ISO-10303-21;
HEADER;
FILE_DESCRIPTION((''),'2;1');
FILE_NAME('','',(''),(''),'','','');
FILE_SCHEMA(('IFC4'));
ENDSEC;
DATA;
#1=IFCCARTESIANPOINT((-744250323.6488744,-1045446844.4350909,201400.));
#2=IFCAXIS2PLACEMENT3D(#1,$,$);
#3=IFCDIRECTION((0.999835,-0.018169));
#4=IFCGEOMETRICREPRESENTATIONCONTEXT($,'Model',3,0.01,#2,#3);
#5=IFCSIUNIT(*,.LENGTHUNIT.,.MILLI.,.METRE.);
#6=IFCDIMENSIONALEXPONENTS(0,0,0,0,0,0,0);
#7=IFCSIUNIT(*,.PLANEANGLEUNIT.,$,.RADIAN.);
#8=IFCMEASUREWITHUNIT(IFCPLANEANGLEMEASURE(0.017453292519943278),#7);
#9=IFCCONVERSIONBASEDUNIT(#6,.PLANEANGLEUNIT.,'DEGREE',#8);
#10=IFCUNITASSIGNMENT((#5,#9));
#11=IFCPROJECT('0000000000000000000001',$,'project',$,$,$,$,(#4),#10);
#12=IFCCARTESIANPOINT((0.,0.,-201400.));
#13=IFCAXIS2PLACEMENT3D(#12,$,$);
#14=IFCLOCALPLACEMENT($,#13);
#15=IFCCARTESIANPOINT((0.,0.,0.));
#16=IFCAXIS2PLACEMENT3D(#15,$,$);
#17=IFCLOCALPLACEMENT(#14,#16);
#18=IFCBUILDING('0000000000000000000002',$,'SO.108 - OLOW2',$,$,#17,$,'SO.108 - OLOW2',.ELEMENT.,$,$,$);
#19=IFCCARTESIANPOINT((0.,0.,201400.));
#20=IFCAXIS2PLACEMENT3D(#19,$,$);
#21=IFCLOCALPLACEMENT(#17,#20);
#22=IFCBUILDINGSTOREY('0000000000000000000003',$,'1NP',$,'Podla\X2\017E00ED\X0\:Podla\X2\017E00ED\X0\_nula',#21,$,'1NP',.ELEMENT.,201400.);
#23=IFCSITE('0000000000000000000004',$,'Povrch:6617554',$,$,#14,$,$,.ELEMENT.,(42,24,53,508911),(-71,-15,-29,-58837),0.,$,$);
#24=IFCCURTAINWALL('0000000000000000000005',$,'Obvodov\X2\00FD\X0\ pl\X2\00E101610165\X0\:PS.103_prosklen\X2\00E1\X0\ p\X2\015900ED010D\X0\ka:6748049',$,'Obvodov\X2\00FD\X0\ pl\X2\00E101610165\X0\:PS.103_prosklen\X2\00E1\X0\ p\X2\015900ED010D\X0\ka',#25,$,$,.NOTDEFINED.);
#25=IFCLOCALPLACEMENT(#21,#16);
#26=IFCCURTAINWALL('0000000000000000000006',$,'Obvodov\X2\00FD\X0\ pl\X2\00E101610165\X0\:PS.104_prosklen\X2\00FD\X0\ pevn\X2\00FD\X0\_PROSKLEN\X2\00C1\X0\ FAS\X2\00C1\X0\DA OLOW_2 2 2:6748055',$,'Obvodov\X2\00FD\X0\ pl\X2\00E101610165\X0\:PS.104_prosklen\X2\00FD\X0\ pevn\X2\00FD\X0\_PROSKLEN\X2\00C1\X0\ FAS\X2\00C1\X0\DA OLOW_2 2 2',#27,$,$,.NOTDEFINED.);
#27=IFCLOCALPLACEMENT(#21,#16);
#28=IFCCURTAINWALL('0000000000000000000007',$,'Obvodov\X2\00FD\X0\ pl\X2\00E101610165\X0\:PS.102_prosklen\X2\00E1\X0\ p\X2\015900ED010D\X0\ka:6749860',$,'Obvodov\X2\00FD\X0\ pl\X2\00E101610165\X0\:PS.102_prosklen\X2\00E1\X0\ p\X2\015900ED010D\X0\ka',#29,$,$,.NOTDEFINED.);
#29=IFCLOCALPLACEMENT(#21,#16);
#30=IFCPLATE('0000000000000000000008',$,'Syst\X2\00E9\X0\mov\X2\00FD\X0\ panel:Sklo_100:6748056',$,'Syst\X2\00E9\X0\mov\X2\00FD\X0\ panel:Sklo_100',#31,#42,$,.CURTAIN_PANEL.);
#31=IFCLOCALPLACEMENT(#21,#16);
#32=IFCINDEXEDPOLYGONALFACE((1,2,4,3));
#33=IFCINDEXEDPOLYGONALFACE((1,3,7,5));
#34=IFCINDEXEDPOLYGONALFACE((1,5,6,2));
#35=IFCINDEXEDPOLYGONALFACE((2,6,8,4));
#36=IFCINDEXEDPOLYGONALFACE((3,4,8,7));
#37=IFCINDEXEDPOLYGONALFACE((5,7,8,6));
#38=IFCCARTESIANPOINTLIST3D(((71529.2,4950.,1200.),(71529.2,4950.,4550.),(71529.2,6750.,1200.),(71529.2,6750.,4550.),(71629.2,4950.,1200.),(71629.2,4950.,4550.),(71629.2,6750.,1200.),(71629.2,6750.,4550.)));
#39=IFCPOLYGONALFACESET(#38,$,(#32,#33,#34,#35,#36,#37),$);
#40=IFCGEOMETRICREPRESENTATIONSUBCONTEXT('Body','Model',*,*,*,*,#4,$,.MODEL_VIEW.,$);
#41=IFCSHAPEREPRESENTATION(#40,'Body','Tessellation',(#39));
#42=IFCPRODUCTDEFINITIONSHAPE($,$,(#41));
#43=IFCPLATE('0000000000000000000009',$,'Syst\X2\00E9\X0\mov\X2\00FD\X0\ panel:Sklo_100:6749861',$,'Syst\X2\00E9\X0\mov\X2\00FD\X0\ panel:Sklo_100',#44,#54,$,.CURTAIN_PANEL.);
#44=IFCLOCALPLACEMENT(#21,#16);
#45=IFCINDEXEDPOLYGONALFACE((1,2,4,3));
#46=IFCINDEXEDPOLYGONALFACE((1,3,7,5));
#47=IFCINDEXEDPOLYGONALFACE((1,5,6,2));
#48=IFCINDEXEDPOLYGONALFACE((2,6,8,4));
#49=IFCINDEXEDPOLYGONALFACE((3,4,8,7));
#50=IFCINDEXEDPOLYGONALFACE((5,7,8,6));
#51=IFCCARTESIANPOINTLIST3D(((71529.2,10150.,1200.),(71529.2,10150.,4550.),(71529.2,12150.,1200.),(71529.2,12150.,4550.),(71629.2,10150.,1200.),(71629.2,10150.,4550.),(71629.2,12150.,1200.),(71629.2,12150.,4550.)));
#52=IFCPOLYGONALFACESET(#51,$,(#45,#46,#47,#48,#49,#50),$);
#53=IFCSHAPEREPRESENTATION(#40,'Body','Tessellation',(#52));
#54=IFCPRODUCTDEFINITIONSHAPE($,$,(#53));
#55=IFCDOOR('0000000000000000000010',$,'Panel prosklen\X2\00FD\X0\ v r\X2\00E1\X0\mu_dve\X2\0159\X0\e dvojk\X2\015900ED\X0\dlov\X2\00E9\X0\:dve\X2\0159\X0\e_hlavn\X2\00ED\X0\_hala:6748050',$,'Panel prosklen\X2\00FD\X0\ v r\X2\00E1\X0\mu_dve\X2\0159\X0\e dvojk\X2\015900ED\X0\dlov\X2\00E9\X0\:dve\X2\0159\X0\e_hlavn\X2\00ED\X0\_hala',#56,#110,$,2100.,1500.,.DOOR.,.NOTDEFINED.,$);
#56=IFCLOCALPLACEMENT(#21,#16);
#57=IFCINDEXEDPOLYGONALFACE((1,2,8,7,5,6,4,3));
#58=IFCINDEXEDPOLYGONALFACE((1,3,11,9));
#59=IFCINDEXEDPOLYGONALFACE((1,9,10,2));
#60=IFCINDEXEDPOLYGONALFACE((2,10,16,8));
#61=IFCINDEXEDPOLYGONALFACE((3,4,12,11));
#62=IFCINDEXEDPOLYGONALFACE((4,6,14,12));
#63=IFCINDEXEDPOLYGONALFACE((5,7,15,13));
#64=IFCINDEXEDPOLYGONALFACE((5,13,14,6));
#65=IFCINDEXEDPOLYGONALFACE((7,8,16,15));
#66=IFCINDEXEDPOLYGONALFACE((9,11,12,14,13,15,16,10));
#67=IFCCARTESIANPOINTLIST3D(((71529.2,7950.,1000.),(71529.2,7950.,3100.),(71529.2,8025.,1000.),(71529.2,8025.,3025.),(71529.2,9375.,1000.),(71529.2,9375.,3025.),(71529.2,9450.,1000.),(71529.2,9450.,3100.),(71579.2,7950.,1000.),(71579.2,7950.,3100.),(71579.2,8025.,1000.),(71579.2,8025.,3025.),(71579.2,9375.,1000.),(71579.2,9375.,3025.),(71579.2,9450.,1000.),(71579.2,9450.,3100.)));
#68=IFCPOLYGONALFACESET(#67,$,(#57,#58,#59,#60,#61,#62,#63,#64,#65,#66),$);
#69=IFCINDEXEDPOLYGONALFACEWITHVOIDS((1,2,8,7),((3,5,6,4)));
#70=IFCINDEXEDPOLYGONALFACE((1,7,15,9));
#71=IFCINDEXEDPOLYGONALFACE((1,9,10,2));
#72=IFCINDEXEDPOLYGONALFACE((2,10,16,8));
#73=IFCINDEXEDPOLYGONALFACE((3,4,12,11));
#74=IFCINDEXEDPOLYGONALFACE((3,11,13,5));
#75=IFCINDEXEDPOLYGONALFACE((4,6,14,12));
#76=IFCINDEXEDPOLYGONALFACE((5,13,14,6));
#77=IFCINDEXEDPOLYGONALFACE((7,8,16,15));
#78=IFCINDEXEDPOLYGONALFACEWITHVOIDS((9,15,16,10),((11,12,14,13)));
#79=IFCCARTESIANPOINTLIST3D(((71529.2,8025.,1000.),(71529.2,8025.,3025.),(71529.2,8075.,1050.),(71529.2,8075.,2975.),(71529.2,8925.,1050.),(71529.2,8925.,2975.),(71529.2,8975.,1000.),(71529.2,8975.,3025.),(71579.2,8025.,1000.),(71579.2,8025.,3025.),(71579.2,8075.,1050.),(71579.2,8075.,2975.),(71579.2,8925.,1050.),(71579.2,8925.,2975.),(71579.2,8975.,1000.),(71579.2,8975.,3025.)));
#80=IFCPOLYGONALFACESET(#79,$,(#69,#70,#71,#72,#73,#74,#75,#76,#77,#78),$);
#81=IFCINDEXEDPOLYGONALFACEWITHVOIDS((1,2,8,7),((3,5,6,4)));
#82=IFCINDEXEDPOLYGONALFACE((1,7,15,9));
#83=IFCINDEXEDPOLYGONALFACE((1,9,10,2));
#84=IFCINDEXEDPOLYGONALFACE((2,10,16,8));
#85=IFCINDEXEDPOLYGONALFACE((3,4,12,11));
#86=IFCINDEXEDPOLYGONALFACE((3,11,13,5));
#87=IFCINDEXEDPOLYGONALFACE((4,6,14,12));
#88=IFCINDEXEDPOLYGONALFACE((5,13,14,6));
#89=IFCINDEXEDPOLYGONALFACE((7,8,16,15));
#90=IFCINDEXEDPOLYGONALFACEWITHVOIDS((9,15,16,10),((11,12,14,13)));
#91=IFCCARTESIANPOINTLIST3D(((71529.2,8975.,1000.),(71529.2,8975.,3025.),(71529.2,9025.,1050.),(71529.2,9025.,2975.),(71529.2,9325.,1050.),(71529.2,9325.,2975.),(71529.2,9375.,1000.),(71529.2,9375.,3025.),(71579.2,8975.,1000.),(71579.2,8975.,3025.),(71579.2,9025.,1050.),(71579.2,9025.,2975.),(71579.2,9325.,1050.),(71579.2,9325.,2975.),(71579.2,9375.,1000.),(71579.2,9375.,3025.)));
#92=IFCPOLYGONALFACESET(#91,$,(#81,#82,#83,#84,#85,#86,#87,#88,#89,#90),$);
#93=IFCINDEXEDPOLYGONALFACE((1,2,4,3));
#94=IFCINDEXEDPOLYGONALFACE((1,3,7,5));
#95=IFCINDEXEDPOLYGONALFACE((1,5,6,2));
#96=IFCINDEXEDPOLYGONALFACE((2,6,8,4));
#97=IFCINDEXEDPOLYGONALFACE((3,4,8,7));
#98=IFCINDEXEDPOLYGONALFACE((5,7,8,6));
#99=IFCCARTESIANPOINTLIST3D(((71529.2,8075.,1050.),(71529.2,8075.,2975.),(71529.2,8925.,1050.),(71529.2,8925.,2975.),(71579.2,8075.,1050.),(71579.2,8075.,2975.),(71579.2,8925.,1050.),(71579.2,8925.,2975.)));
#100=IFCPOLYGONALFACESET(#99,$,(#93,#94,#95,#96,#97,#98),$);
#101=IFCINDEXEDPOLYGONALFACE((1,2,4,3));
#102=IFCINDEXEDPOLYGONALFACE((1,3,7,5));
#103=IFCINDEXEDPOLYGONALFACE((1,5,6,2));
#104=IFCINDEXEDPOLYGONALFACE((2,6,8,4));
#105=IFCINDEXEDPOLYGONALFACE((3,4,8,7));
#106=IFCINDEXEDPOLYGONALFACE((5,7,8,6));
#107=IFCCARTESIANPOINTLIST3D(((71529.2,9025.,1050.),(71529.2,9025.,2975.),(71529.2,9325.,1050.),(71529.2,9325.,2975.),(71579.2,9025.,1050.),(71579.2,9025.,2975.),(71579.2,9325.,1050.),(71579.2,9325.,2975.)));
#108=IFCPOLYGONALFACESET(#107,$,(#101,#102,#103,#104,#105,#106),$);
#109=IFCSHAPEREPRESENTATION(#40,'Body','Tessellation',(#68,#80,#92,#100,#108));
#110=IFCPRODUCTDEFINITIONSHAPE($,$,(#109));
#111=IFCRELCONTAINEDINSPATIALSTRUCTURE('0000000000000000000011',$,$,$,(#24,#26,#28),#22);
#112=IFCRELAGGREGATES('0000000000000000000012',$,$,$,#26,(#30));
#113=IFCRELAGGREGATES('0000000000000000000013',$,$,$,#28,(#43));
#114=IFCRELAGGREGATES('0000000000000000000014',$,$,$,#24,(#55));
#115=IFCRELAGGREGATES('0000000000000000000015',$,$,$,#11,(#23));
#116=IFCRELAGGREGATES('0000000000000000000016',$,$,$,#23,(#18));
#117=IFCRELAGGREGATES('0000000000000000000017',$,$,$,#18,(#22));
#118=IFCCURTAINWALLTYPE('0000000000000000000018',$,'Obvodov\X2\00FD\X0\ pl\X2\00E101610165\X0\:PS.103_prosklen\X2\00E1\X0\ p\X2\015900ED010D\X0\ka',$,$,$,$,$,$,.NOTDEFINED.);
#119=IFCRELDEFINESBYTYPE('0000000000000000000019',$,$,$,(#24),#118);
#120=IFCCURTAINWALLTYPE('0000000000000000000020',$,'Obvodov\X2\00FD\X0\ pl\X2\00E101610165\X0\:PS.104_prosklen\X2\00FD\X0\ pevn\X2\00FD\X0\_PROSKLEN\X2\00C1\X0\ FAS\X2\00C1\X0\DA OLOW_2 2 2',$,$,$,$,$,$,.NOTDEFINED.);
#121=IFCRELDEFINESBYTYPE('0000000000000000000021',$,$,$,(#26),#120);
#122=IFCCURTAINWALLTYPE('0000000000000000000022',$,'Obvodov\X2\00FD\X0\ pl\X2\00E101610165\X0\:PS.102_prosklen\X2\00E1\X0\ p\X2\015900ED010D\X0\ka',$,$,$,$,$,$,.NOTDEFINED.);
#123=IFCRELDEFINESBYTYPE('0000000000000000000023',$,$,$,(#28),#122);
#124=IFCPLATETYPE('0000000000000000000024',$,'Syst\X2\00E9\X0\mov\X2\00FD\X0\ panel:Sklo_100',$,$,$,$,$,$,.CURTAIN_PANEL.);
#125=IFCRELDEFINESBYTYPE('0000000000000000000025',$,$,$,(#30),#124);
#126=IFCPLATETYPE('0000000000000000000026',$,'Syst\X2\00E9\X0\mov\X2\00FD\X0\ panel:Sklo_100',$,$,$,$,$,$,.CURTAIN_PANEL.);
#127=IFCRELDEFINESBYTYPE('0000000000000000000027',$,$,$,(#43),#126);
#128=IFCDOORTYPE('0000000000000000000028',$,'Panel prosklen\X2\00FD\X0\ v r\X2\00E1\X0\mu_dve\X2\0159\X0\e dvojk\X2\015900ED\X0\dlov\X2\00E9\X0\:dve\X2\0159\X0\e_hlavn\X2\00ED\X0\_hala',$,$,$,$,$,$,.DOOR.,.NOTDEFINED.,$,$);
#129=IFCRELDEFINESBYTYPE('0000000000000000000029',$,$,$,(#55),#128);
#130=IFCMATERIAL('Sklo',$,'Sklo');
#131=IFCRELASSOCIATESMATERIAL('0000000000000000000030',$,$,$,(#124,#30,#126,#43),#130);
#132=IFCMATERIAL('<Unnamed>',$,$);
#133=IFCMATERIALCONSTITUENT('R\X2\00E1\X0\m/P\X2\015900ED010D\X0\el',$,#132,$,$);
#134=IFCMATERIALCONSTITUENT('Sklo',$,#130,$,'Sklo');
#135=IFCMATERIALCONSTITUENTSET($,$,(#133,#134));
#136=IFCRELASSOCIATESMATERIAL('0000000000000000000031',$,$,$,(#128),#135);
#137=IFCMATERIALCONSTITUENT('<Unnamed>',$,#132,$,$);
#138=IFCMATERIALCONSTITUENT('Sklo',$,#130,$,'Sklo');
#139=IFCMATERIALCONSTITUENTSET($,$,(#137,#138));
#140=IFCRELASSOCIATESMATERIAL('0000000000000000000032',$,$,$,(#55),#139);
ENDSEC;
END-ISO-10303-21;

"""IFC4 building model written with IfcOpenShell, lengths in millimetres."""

from ifc_helpers import new_model, entity, si_unit, converted_unit, direction, frame, origin, place, context, subcontext, project, spatial, indexed_curve, outline, extrude, source, transform, mapped, material, constituent, constituent_set, type_object, type_shapes, element, aggregate, save


model = new_model("IFC4")

# Units and contexts
model_context = context("Model", 3, precision=0.01, world=frame((-744250323.6488744, -1045446844.4350909, 201400.0)), true_north=direction((0.999835, -0.018169)))
body_context = subcontext(model_context, "Body", "Model", "MODEL_VIEW")
ifc_project = project(units=[si_unit("LENGTHUNIT", "METRE", prefix="MILLI"), converted_unit("PLANEANGLEUNIT", "DEGREE", entity("IfcPlaneAngleMeasure", 0.017453292519943278), si_unit("PLANEANGLEUNIT", "RADIAN"), dimensions=[0, 0, 0, 0, 0, 0, 0])], contexts=[model_context])

# Site, building, storey
site_placement = place(None, frame((0.0, 0.0, -201400.0)))
site = spatial("IfcSite", under=ifc_project, at=site_placement, Name="Povrch:6617554", CompositionType="ELEMENT", RefLatitude=(42, 24, 53, 508911), RefLongitude=(-71, -15, -29, -58837), RefElevation=0.0)
building_placement = place(site_placement, origin())
building = spatial("IfcBuilding", under=site, at=building_placement, Name="SO.108 - OLOW2", LongName="SO.108 - OLOW2", CompositionType="ELEMENT")
storey_placement = place(building_placement, frame((0.0, 0.0, 201400.0)))
storey = spatial("IfcBuildingStorey", under=building, at=storey_placement, Name="1NP", ObjectType="Podlaží:Podlaží_nula", LongName="1NP", CompositionType="ELEMENT", Elevation=201400.0)

# Curtain walls
curtain_wall_type_1 = type_object("IfcCurtainWallType", Name="Obvodový plášť:PS.103_prosklená příčka", PredefinedType="NOTDEFINED")
curtain_wall_1_placement = place(storey_placement, frame((0.0, 0.0, -201400.0)))
curtain_wall_1 = element("IfcCurtainWall", 1, at=curtain_wall_1_placement, inside=storey, type_object=curtain_wall_type_1, Name="Obvodový plášť:PS.103_prosklená příčka:6748049", ObjectType="Obvodový plášť:PS.103_prosklená příčka", PredefinedType="NOTDEFINED")
ifc_material_1 = material(Name="<Unnamed>")
curtain_wall_type_2 = type_object("IfcCurtainWallType", Name="Obvodový plášť:PS.104_prosklený pevný_PROSKLENÁ FASÁDA OLOW_2 2 2", PredefinedType="NOTDEFINED")
curtain_wall_2_placement = place(storey_placement, frame((0.0, 0.0, -201400.0)))
curtain_wall_2 = element("IfcCurtainWall", 2, at=curtain_wall_2_placement, inside=storey, type_object=curtain_wall_type_2, Name="Obvodový plášť:PS.104_prosklený pevný_PROSKLENÁ FASÁDA OLOW_2 2 2:6748055", ObjectType="Obvodový plášť:PS.104_prosklený pevný_PROSKLENÁ FASÁDA OLOW_2 2 2", PredefinedType="NOTDEFINED")
curtain_wall_type_3 = type_object("IfcCurtainWallType", Name="Obvodový plášť:PS.102_prosklená příčka", PredefinedType="NOTDEFINED")
curtain_wall_3_placement = place(storey_placement, frame((0.0, 0.0, -201400.0)))
curtain_wall_3 = element("IfcCurtainWall", 3, at=curtain_wall_3_placement, inside=storey, type_object=curtain_wall_type_3, Name="Obvodový plášť:PS.102_prosklená příčka:6749860", ObjectType="Obvodový plášť:PS.102_prosklená příčka", PredefinedType="NOTDEFINED")

# Plates
ifc_material_2 = material(Name="Sklo", Category="Sklo")
plate_type_1 = type_object("IfcPlateType", Name="Systémový panel:Sklo_100", PredefinedType="CURTAIN_PANEL", material=ifc_material_2)
shared_shape_1 = source(origin(), body_context, "Body", "SweptSolid", [
    extrude(outline(indexed_curve([(-50.0, -900.0), (50.0, -900.0), (50.0, 900.0), (-50.0, 900.0), (-50.0, -900.0)], self_intersect=False)), frame((0.0, 50.0, 0.0), z_axis=(0.0, 0.0, 1.0), x_axis=(0.0, 1.0, 0.0)), (0.0, 0.0, 1.0), 3350.0),
])
type_shapes(plate_type_1, [shared_shape_1])
plate_1_placement = place(curtain_wall_2_placement, frame((71529.2, 5850.0, 202600.0), z_axis=(0.0, 0.0, 1.0), x_axis=(0.0, -1.0, 0.0)))
plate_1 = element("IfcPlate", 4, at=plate_1_placement, type_object=plate_type_1, material=ifc_material_2, Name="Systémový panel:Sklo_100:6748056", ObjectType="Systémový panel:Sklo_100", PredefinedType="CURTAIN_PANEL", context=body_context, shape_type="MappedRepresentation", body=[
    mapped(shared_shape_1, transform((0.0, 0.0, 0.0), scale=1.0)),
])
aggregate(curtain_wall_2, [plate_1])
plate_type_2 = type_object("IfcPlateType", Name="Systémový panel:Sklo_100", PredefinedType="CURTAIN_PANEL", material=ifc_material_2)
shared_shape_2 = source(origin(), body_context, "Body", "SweptSolid", [
    extrude(outline(indexed_curve([(-50.0, -1000.0), (50.0, -1000.0), (50.0, 1000.0), (-50.0, 1000.0), (-50.0, -1000.0)], self_intersect=False)), frame((0.0, -50.0, 0.0), z_axis=(0.0, 0.0, 1.0), x_axis=(0.0, 1.0, 0.0)), (0.0, 0.0, 1.0), 3350.0),
])
type_shapes(plate_type_2, [shared_shape_2])
plate_2_placement = place(curtain_wall_3_placement, frame((71529.2, 11150.0, 202600.0), z_axis=(0.0, 0.0, 1.0), x_axis=(0.0, 1.0, 0.0)))
plate_2 = element("IfcPlate", 5, at=plate_2_placement, type_object=plate_type_2, material=ifc_material_2, Name="Systémový panel:Sklo_100:6749861", ObjectType="Systémový panel:Sklo_100", PredefinedType="CURTAIN_PANEL", context=body_context, shape_type="MappedRepresentation", body=[
    mapped(shared_shape_2, transform((0.0, 0.0, 0.0), scale=1.0)),
])
aggregate(curtain_wall_3, [plate_2])

# Door
ifc_constituent_1 = constituent(ifc_material_1, Name="<Unnamed>")
ifc_constituent_2 = constituent(ifc_material_2, Name="Sklo", Category="Sklo")
ifc_constituent_set_1 = constituent_set(constituents=[ifc_constituent_1, ifc_constituent_2])
ifc_constituent_3 = constituent(ifc_material_1, Name="Rám/Příčel")
ifc_constituent_4 = constituent(ifc_material_2, Name="Sklo", Category="Sklo")
ifc_constituent_set_2 = constituent_set(constituents=[ifc_constituent_3, ifc_constituent_4])
door_type = type_object("IfcDoorType", Name="Panel prosklený v rámu_dveře dvojkřídlové:dveře_hlavní_hala", OperationType="NOTDEFINED", PredefinedType="DOOR", material=ifc_constituent_set_2)
shared_shape_3 = source(origin(), body_context, "Body", "SweptSolid", [
    extrude(outline(indexed_curve([(-750.0, -1068.7), (750.0, -1068.7), (750.0, 1031.2), (675.0, 1031.2), (675.0, -993.7), (-675.0, -993.7), (-675.0, 1031.2), (-750.0, 1031.2), (-750.0, -1068.7)], self_intersect=False)), frame((0.0, 0.0, 1031.2), z_axis=(0.0, 1.0, 0.0), x_axis=(1.0, 0.0, 0.0)), (0.0, 0.0, 1.0), 50.0),
    extrude(outline(indexed_curve([(-1012.5, -475.0), (1012.5, -475.0), (1012.5, 475.0), (-1012.5, 475.0), (-1012.5, -475.0)], self_intersect=False), holes=[indexed_curve([(-962.5, -425.0), (-962.5, 425.0), (962.5, 425.0), (962.5, -425.0), (-962.5, -425.0)], self_intersect=False)]), frame((200.0, 0.0, 1012.5), z_axis=(0.0, 1.0, 0.0), x_axis=(0.0, 0.0, -1.0)), (0.0, 0.0, 1.0), 50.0),
    extrude(outline(indexed_curve([(-1012.5, -200.0), (1012.5, -200.0), (1012.5, 200.0), (-1012.5, 200.0), (-1012.5, -200.0)], self_intersect=False), holes=[indexed_curve([(-962.5, -150.0), (-962.5, 150.0), (962.5, 150.0), (962.5, -150.0), (-962.5, -150.0)], self_intersect=False)]), frame((-475.0, 0.0, 1012.5), z_axis=(0.0, 1.0, 0.0), x_axis=(0.0, 0.0, -1.0)), (0.0, 0.0, 1.0), 50.0),
    extrude(outline(indexed_curve([(-25.0, -425.0), (25.0, -425.0), (25.0, 425.0), (-25.0, 425.0), (-25.0, -425.0)], self_intersect=False)), frame((200.0, 25.0, 50.0), z_axis=(0.0, 0.0, 1.0), x_axis=(0.0, 1.0, 0.0)), (0.0, 0.0, 1.0), 1925.0),
    extrude(outline(indexed_curve([(-25.0, -150.0), (25.0, -150.0), (25.0, 150.0), (-25.0, 150.0), (-25.0, -150.0)], self_intersect=False)), frame((-475.0, 25.0, 50.0), z_axis=(0.0, 0.0, 1.0), x_axis=(0.0, 1.0, 0.0)), (0.0, 0.0, 1.0), 1925.0),
])
type_shapes(door_type, [shared_shape_3])
door_placement = place(curtain_wall_1_placement, frame((71529.2, 8700.0, 202400.0), z_axis=(0.0, 0.0, 1.0), x_axis=(0.0, -1.0, 0.0)))
door = element("IfcDoor", 6, at=door_placement, type_object=door_type, material=ifc_constituent_set_1, Name="Panel prosklený v rámu_dveře dvojkřídlové:dveře_hlavní_hala:6748050", ObjectType="Panel prosklený v rámu_dveře dvojkřídlové:dveře_hlavní_hala", OperationType="NOTDEFINED", OverallHeight=2100.0, OverallWidth=1500.0, PredefinedType="DOOR", context=body_context, shape_type="MappedRepresentation", body=[
    mapped(shared_shape_3, transform((0.0, 0.0, 0.0), scale=1.0)),
])
aggregate(curtain_wall_1, [door])

save(model, "model.ifc")
